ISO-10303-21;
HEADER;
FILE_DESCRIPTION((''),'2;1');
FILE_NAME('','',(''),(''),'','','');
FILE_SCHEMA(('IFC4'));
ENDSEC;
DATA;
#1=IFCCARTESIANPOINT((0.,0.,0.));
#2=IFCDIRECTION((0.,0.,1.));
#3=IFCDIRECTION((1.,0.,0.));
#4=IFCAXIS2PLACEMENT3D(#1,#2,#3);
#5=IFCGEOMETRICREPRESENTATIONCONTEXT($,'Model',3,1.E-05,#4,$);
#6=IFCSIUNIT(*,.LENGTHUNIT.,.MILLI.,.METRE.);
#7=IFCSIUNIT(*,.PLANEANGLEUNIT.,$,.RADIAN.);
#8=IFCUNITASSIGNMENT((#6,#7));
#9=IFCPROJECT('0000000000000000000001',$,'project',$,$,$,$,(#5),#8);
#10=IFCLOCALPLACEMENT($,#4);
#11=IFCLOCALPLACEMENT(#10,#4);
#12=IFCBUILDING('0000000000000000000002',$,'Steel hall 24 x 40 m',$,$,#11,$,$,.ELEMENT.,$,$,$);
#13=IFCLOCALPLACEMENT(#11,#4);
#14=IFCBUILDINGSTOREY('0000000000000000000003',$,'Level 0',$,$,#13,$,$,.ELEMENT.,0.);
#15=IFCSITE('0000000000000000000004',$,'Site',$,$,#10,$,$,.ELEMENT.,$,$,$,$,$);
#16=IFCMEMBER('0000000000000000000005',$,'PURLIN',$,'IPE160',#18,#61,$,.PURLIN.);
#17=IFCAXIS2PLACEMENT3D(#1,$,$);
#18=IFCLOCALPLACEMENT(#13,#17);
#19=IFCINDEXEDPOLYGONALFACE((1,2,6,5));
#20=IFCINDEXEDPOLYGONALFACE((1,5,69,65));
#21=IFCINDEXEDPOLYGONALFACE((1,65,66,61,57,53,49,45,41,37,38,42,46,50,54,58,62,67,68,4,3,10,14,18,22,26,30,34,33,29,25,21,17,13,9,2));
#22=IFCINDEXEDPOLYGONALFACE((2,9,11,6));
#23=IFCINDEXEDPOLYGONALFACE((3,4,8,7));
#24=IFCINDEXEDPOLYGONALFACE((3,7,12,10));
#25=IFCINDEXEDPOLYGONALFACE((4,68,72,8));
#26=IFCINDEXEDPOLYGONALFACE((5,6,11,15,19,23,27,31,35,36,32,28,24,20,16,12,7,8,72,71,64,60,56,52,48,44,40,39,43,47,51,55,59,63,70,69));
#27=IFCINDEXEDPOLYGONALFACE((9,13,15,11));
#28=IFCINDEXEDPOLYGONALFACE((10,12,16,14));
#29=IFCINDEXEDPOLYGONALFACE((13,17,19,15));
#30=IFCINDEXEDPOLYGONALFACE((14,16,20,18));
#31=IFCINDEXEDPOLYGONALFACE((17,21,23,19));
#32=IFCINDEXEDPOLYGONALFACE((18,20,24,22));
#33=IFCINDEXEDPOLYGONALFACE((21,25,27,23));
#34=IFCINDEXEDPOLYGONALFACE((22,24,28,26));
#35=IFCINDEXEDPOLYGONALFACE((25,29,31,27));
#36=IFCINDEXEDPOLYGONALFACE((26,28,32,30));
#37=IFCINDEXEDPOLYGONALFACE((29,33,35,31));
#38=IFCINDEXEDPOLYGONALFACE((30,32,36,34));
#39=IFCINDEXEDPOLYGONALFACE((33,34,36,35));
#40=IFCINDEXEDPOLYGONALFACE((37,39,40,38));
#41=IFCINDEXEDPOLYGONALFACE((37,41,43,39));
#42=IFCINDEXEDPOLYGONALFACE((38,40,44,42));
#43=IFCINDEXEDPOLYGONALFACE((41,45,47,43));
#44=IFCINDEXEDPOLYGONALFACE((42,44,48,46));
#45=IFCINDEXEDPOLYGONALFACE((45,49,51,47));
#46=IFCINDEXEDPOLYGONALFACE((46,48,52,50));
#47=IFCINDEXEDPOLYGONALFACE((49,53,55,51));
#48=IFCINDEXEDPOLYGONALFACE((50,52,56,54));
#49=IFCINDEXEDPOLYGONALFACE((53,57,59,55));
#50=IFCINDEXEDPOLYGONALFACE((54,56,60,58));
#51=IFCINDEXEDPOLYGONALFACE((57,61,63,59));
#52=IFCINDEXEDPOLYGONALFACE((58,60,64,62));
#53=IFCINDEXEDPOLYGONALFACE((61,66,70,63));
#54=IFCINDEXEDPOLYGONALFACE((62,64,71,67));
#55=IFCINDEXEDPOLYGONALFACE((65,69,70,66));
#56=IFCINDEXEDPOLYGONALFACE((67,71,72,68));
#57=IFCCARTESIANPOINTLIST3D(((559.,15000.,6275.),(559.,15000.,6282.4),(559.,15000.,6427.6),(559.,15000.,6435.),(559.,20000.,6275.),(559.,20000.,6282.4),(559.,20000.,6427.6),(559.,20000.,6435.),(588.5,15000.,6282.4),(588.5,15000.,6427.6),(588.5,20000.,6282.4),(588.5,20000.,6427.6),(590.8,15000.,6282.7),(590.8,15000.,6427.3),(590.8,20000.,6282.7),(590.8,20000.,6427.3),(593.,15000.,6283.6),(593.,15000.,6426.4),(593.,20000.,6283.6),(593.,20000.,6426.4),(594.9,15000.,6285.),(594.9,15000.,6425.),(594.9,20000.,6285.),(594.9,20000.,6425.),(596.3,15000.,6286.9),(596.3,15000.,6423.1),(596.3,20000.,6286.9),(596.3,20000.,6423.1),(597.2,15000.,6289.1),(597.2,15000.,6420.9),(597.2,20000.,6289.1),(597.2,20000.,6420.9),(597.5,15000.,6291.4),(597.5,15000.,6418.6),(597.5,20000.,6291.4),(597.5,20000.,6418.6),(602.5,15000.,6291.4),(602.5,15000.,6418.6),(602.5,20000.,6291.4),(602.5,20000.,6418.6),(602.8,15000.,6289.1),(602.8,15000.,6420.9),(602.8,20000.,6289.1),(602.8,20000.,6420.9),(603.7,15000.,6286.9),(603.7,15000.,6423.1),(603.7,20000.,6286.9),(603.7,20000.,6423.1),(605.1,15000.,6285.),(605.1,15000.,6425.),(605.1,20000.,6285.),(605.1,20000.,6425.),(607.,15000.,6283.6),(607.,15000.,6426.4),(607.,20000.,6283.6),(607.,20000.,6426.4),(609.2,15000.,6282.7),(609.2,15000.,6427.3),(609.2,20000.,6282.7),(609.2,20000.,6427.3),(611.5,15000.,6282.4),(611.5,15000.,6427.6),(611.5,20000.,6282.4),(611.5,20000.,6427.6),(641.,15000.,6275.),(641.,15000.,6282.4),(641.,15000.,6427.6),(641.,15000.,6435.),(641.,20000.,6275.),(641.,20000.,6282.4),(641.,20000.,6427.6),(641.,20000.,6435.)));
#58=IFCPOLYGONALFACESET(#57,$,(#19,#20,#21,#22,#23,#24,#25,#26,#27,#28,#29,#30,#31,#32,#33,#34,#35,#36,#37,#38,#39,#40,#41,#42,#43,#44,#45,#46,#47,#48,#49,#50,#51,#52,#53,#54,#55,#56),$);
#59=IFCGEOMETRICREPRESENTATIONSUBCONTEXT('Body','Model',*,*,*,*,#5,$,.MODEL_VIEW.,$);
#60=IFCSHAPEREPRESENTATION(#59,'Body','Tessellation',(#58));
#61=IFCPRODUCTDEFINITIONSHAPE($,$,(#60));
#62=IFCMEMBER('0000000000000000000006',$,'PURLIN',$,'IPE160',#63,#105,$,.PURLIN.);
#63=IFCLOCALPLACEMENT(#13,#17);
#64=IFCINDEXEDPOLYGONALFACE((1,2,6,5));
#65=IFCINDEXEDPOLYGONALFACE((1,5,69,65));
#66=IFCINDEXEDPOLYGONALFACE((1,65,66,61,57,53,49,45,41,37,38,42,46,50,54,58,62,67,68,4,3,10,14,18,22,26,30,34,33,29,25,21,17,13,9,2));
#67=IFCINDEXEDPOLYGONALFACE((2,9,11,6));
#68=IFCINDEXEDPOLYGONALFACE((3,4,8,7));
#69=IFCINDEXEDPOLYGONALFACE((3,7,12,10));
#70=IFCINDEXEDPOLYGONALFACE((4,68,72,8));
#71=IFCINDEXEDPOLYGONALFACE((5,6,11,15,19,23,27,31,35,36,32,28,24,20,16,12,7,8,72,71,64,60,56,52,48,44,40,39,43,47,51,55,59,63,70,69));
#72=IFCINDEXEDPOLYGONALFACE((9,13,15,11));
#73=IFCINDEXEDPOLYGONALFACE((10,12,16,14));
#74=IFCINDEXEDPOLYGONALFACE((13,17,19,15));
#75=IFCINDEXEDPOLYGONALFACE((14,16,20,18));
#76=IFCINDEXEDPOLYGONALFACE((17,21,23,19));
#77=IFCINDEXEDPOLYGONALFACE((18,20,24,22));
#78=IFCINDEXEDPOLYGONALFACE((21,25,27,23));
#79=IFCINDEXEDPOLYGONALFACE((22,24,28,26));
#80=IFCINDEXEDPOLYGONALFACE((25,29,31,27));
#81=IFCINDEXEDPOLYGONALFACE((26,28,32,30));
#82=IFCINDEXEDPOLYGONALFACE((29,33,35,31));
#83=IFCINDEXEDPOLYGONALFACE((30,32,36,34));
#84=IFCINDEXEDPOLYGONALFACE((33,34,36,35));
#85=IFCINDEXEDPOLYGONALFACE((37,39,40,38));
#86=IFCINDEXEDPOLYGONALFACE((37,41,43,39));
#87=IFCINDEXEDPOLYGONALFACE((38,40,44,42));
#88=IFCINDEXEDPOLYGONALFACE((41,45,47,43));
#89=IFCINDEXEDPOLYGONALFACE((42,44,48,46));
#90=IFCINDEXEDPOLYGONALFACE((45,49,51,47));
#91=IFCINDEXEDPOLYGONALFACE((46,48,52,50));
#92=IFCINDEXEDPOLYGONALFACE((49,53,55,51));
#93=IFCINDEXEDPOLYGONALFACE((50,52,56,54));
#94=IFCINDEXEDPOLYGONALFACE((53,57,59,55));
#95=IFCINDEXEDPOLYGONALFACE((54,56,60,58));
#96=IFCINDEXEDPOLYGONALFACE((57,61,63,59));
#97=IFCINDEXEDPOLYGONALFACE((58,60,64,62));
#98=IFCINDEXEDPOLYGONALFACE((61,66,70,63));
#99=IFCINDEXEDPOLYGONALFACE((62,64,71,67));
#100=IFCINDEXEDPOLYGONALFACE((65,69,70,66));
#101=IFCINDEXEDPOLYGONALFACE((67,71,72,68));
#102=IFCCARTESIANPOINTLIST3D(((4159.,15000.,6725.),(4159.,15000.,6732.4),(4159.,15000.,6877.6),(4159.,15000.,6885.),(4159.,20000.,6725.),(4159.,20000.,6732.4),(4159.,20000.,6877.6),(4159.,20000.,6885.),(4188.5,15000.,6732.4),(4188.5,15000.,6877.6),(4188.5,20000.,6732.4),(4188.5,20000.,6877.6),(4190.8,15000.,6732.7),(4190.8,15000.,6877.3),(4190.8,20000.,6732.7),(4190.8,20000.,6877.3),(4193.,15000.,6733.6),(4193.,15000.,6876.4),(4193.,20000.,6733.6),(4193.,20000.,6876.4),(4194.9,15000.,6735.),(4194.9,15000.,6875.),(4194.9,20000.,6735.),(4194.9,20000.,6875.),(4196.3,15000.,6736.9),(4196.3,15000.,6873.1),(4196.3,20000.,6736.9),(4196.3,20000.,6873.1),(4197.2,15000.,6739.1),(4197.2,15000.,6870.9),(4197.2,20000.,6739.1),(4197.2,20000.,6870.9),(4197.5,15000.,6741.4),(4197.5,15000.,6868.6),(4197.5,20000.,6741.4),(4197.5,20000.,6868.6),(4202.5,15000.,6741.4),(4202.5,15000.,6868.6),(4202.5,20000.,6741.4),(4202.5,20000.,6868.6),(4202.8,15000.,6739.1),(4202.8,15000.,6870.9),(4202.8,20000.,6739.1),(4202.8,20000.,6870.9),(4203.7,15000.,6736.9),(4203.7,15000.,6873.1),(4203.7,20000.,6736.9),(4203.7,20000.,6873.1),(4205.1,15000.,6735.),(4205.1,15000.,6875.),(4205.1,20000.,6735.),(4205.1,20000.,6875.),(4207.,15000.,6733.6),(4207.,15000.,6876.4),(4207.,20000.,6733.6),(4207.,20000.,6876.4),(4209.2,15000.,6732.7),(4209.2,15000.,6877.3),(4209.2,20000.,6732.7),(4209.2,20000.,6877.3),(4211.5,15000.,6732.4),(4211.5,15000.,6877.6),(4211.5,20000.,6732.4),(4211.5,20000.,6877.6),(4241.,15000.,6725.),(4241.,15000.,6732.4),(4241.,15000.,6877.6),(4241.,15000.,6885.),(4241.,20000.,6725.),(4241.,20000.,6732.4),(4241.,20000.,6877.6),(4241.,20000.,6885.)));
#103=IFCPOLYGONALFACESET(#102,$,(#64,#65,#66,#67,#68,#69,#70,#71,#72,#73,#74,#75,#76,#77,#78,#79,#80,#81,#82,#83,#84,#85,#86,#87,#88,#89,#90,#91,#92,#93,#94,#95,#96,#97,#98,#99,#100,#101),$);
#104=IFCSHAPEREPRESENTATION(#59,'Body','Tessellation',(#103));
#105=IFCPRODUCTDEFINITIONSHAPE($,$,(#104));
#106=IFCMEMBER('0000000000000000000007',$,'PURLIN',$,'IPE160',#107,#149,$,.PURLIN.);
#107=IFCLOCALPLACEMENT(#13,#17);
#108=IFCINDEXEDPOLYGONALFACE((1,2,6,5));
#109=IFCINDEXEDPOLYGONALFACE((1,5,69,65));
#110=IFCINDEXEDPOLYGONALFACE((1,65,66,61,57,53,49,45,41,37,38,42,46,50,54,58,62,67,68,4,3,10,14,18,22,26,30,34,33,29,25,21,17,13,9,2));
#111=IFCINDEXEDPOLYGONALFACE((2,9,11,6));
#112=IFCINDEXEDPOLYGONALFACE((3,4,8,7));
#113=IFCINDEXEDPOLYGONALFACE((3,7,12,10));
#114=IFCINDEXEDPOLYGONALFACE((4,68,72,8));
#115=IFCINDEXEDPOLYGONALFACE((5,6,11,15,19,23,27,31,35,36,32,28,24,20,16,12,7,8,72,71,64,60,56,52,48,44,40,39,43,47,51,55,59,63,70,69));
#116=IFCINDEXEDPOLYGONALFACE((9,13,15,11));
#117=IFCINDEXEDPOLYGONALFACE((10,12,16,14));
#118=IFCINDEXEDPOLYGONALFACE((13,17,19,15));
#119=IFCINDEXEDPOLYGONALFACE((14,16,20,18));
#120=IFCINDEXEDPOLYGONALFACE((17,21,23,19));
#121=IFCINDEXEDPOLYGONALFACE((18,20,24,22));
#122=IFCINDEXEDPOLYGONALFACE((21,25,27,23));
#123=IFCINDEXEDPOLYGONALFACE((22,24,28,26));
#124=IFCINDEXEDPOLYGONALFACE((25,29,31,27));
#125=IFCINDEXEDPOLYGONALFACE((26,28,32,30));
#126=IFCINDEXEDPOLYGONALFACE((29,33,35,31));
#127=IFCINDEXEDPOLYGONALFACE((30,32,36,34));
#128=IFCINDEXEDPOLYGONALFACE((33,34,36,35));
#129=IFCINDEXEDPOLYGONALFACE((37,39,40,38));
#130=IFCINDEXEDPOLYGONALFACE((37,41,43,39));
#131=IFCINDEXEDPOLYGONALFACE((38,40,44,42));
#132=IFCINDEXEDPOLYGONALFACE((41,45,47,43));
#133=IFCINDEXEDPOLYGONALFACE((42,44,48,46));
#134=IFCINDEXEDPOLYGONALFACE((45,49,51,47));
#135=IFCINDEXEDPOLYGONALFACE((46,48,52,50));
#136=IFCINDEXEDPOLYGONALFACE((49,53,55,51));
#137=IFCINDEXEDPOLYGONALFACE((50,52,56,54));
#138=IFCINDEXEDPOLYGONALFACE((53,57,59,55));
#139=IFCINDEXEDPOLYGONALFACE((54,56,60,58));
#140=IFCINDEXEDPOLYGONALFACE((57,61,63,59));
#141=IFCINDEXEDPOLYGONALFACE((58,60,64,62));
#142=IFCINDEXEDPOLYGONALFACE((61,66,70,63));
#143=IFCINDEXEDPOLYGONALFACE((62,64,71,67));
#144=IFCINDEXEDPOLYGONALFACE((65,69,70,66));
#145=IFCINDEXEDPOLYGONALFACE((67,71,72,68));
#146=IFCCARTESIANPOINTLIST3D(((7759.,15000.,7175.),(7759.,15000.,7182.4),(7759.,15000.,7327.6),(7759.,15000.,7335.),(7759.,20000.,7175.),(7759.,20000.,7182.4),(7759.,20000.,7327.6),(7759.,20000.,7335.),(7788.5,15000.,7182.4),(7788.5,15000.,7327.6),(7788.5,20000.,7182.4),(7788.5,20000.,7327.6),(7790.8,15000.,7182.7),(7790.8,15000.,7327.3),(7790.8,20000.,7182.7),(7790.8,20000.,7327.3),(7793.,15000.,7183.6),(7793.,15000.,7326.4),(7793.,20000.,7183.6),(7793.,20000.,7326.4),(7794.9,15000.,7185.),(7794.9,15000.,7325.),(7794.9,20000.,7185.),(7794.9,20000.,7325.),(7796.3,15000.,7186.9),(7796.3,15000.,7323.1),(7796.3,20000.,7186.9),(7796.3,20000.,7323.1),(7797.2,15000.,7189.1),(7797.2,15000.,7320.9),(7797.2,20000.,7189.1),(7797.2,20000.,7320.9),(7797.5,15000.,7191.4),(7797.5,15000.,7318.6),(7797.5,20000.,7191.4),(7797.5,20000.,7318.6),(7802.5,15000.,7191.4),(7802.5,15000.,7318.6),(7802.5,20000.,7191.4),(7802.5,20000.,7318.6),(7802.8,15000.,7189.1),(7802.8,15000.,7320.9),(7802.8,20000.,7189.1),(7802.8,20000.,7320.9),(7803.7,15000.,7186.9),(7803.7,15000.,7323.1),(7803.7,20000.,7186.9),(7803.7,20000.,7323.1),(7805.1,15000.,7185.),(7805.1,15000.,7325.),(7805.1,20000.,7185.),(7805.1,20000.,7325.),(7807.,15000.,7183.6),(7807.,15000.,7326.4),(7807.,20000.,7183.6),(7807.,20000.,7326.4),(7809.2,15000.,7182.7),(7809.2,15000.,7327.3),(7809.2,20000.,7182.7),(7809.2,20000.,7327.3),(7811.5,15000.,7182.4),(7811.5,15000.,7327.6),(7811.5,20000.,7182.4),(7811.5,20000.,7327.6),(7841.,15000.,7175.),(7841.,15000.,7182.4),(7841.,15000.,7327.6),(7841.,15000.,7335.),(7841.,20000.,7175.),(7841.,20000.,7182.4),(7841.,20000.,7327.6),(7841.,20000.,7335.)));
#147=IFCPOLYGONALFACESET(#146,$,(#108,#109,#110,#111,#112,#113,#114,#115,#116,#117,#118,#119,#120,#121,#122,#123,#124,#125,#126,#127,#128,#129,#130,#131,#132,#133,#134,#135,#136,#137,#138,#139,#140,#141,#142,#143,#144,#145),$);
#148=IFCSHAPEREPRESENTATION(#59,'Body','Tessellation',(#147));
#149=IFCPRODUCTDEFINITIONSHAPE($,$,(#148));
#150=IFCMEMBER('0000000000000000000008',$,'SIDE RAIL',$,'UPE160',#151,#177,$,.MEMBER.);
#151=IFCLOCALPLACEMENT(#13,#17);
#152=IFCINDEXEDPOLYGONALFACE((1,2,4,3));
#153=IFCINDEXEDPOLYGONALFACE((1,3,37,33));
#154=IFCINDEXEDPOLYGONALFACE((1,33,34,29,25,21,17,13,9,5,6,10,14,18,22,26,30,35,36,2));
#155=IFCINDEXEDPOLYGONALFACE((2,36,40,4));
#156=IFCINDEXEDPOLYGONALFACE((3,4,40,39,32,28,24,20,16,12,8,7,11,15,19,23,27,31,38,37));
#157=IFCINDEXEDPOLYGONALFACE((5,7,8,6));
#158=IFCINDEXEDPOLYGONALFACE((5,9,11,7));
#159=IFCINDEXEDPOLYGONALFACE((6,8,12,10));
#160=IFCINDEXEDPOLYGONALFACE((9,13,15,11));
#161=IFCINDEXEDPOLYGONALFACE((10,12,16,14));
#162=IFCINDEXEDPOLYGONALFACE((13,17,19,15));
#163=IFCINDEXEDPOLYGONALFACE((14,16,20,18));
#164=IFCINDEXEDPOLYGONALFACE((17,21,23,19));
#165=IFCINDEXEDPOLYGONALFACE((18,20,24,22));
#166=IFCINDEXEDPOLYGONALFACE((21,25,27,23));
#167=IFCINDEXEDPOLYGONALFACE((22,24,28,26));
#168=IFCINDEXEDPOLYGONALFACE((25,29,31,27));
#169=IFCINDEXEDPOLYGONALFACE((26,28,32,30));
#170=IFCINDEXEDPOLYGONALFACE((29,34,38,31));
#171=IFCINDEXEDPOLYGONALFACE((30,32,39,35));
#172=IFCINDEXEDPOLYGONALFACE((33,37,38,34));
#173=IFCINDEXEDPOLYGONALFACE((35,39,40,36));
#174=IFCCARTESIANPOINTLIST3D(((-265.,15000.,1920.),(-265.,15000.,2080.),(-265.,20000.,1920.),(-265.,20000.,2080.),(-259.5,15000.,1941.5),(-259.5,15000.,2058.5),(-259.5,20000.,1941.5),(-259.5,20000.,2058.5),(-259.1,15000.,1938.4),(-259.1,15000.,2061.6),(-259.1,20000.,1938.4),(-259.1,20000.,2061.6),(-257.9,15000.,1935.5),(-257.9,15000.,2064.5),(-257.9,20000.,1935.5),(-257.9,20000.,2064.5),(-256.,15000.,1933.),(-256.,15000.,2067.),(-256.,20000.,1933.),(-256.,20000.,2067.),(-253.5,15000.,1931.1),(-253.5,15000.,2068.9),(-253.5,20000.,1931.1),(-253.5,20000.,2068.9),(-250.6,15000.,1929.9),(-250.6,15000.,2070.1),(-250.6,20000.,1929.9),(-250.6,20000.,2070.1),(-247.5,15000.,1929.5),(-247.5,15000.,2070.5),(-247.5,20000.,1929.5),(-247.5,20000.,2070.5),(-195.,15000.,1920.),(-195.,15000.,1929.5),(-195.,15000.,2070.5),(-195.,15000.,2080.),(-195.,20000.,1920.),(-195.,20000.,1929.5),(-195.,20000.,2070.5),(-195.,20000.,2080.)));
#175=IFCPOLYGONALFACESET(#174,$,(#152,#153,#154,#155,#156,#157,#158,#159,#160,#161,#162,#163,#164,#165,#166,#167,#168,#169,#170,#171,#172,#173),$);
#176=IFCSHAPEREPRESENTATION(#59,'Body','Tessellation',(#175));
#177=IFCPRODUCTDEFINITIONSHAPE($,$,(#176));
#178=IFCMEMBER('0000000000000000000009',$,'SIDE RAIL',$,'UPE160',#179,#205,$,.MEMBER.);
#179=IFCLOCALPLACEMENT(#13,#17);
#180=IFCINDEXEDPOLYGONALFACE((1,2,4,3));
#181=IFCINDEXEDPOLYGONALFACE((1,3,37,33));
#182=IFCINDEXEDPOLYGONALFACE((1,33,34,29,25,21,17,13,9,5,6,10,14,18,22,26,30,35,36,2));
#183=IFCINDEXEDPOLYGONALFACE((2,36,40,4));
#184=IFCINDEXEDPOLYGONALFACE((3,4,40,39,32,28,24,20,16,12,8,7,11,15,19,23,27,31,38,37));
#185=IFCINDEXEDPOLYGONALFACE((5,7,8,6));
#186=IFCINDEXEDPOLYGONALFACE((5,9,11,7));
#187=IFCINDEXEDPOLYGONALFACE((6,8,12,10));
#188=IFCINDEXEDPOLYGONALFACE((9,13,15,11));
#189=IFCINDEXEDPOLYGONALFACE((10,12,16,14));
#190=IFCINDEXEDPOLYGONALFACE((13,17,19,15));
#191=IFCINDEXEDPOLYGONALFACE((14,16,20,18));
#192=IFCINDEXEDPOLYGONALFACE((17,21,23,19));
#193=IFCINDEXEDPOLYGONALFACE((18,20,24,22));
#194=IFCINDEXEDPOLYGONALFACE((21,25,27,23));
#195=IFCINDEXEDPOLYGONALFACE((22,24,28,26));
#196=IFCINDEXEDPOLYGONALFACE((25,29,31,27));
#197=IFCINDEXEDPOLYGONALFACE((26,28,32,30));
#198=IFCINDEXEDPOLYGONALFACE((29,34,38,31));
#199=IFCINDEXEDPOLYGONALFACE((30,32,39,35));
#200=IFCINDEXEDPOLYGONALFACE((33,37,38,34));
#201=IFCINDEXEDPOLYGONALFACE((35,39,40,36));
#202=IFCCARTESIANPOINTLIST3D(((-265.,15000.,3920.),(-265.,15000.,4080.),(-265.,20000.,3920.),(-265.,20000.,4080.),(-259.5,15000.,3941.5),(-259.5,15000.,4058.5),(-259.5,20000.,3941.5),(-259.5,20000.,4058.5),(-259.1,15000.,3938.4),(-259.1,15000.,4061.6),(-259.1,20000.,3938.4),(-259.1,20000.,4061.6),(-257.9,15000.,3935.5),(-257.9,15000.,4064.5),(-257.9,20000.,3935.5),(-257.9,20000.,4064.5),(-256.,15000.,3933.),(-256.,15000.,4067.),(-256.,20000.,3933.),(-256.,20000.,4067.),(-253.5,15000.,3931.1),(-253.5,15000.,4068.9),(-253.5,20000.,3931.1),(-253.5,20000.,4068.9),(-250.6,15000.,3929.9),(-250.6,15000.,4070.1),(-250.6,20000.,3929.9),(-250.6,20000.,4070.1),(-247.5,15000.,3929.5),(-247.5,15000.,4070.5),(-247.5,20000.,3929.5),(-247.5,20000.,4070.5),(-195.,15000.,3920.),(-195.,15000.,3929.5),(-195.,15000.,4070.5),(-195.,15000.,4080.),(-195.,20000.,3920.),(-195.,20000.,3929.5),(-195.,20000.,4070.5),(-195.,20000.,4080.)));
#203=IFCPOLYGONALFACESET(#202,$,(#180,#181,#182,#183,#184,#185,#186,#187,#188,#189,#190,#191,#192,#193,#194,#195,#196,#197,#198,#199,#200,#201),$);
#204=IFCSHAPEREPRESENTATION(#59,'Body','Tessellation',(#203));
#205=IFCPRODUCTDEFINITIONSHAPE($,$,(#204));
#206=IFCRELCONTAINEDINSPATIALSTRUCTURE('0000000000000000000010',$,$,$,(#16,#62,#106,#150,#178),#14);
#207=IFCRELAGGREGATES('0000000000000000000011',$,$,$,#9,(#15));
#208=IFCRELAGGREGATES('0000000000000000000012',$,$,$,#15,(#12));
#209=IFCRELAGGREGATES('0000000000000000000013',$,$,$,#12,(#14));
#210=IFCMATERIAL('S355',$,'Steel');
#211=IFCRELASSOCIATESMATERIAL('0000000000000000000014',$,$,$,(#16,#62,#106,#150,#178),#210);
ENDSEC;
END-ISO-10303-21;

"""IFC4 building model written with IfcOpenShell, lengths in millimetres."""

from ifc_helpers import new_model, si_unit, frame, origin_with_axes, place, context, subcontext, project, spatial, i_section, u_section, extrude, material, element, save


model = new_model("IFC4")

# Units and contexts
model_context = context("Model", 3, precision=1e-05, world=origin_with_axes())
body_context = subcontext(model_context, "Body", "Model", "MODEL_VIEW")
ifc_project = project(units=[si_unit("LENGTHUNIT", "METRE", prefix="MILLI"), si_unit("PLANEANGLEUNIT", "RADIAN")], contexts=[model_context])

# Site, building, storey
site_placement = place(None, origin_with_axes())
site = spatial("IfcSite", under=ifc_project, at=site_placement, Name="Site", CompositionType="ELEMENT")
building_placement = place(site_placement, origin_with_axes())
building = spatial("IfcBuilding", under=site, at=building_placement, Name="Steel hall 24 x 40 m", CompositionType="ELEMENT")
storey_placement = place(building_placement, origin_with_axes())
storey = spatial("IfcBuildingStorey", under=building, at=storey_placement, Name="Level 0", CompositionType="ELEMENT", Elevation=0.0)

# Shared definitions
ifc_material = material(Name="S355", Category="Steel")

# Members
for number, where, z_axis, x_axis, name in (
    (1, (600.0, 15000.0, 6355.0), (0.0, 1.0, 0.0), (1.0, 0.0, 0.0), "PURLIN"),
    (2, (4200.0, 15000.0, 6805.0), (0.0, 1.0, 0.0), (1.0, 0.0, 0.0), "PURLIN"),
    (3, (7800.0, 15000.0, 7255.0), (0.0, 1.0, 0.0), (1.0, 0.0, 0.0), "PURLIN"),
):
    element("IfcMember", number, at=place(storey_placement, frame(where, z_axis=z_axis, x_axis=x_axis)), inside=storey, material=ifc_material, Name=name, ObjectType="IPE160", PredefinedType="PURLIN", context=body_context, shape_type="SweptSolid", body=[
        extrude(i_section(OverallWidth=82.0, OverallDepth=160.0, WebThickness=5.0, FlangeThickness=7.4, FilletRadius=9.0), origin_with_axes(), (0.0, 0.0, 1.0), 5000.0),
    ])
for number, where, z_axis, x_axis, name in (
    (4, (-230.0, 15000.0, 2000.0), (0.0, 1.0, 0.0), (1.0, 0.0, 0.0), "SIDE RAIL"),
    (5, (-230.0, 15000.0, 4000.0), (0.0, 1.0, 0.0), (1.0, 0.0, 0.0), "SIDE RAIL"),
):
    element("IfcMember", number, at=place(storey_placement, frame(where, z_axis=z_axis, x_axis=x_axis)), inside=storey, material=ifc_material, Name=name, ObjectType="UPE160", PredefinedType="MEMBER", context=body_context, shape_type="SweptSolid", body=[
        extrude(u_section(Depth=160.0, FlangeWidth=70.0, WebThickness=5.5, FlangeThickness=9.5, FilletRadius=12.0), origin_with_axes(), (0.0, 0.0, 1.0), 5000.0),
    ])

save(model, "model.ifc")
